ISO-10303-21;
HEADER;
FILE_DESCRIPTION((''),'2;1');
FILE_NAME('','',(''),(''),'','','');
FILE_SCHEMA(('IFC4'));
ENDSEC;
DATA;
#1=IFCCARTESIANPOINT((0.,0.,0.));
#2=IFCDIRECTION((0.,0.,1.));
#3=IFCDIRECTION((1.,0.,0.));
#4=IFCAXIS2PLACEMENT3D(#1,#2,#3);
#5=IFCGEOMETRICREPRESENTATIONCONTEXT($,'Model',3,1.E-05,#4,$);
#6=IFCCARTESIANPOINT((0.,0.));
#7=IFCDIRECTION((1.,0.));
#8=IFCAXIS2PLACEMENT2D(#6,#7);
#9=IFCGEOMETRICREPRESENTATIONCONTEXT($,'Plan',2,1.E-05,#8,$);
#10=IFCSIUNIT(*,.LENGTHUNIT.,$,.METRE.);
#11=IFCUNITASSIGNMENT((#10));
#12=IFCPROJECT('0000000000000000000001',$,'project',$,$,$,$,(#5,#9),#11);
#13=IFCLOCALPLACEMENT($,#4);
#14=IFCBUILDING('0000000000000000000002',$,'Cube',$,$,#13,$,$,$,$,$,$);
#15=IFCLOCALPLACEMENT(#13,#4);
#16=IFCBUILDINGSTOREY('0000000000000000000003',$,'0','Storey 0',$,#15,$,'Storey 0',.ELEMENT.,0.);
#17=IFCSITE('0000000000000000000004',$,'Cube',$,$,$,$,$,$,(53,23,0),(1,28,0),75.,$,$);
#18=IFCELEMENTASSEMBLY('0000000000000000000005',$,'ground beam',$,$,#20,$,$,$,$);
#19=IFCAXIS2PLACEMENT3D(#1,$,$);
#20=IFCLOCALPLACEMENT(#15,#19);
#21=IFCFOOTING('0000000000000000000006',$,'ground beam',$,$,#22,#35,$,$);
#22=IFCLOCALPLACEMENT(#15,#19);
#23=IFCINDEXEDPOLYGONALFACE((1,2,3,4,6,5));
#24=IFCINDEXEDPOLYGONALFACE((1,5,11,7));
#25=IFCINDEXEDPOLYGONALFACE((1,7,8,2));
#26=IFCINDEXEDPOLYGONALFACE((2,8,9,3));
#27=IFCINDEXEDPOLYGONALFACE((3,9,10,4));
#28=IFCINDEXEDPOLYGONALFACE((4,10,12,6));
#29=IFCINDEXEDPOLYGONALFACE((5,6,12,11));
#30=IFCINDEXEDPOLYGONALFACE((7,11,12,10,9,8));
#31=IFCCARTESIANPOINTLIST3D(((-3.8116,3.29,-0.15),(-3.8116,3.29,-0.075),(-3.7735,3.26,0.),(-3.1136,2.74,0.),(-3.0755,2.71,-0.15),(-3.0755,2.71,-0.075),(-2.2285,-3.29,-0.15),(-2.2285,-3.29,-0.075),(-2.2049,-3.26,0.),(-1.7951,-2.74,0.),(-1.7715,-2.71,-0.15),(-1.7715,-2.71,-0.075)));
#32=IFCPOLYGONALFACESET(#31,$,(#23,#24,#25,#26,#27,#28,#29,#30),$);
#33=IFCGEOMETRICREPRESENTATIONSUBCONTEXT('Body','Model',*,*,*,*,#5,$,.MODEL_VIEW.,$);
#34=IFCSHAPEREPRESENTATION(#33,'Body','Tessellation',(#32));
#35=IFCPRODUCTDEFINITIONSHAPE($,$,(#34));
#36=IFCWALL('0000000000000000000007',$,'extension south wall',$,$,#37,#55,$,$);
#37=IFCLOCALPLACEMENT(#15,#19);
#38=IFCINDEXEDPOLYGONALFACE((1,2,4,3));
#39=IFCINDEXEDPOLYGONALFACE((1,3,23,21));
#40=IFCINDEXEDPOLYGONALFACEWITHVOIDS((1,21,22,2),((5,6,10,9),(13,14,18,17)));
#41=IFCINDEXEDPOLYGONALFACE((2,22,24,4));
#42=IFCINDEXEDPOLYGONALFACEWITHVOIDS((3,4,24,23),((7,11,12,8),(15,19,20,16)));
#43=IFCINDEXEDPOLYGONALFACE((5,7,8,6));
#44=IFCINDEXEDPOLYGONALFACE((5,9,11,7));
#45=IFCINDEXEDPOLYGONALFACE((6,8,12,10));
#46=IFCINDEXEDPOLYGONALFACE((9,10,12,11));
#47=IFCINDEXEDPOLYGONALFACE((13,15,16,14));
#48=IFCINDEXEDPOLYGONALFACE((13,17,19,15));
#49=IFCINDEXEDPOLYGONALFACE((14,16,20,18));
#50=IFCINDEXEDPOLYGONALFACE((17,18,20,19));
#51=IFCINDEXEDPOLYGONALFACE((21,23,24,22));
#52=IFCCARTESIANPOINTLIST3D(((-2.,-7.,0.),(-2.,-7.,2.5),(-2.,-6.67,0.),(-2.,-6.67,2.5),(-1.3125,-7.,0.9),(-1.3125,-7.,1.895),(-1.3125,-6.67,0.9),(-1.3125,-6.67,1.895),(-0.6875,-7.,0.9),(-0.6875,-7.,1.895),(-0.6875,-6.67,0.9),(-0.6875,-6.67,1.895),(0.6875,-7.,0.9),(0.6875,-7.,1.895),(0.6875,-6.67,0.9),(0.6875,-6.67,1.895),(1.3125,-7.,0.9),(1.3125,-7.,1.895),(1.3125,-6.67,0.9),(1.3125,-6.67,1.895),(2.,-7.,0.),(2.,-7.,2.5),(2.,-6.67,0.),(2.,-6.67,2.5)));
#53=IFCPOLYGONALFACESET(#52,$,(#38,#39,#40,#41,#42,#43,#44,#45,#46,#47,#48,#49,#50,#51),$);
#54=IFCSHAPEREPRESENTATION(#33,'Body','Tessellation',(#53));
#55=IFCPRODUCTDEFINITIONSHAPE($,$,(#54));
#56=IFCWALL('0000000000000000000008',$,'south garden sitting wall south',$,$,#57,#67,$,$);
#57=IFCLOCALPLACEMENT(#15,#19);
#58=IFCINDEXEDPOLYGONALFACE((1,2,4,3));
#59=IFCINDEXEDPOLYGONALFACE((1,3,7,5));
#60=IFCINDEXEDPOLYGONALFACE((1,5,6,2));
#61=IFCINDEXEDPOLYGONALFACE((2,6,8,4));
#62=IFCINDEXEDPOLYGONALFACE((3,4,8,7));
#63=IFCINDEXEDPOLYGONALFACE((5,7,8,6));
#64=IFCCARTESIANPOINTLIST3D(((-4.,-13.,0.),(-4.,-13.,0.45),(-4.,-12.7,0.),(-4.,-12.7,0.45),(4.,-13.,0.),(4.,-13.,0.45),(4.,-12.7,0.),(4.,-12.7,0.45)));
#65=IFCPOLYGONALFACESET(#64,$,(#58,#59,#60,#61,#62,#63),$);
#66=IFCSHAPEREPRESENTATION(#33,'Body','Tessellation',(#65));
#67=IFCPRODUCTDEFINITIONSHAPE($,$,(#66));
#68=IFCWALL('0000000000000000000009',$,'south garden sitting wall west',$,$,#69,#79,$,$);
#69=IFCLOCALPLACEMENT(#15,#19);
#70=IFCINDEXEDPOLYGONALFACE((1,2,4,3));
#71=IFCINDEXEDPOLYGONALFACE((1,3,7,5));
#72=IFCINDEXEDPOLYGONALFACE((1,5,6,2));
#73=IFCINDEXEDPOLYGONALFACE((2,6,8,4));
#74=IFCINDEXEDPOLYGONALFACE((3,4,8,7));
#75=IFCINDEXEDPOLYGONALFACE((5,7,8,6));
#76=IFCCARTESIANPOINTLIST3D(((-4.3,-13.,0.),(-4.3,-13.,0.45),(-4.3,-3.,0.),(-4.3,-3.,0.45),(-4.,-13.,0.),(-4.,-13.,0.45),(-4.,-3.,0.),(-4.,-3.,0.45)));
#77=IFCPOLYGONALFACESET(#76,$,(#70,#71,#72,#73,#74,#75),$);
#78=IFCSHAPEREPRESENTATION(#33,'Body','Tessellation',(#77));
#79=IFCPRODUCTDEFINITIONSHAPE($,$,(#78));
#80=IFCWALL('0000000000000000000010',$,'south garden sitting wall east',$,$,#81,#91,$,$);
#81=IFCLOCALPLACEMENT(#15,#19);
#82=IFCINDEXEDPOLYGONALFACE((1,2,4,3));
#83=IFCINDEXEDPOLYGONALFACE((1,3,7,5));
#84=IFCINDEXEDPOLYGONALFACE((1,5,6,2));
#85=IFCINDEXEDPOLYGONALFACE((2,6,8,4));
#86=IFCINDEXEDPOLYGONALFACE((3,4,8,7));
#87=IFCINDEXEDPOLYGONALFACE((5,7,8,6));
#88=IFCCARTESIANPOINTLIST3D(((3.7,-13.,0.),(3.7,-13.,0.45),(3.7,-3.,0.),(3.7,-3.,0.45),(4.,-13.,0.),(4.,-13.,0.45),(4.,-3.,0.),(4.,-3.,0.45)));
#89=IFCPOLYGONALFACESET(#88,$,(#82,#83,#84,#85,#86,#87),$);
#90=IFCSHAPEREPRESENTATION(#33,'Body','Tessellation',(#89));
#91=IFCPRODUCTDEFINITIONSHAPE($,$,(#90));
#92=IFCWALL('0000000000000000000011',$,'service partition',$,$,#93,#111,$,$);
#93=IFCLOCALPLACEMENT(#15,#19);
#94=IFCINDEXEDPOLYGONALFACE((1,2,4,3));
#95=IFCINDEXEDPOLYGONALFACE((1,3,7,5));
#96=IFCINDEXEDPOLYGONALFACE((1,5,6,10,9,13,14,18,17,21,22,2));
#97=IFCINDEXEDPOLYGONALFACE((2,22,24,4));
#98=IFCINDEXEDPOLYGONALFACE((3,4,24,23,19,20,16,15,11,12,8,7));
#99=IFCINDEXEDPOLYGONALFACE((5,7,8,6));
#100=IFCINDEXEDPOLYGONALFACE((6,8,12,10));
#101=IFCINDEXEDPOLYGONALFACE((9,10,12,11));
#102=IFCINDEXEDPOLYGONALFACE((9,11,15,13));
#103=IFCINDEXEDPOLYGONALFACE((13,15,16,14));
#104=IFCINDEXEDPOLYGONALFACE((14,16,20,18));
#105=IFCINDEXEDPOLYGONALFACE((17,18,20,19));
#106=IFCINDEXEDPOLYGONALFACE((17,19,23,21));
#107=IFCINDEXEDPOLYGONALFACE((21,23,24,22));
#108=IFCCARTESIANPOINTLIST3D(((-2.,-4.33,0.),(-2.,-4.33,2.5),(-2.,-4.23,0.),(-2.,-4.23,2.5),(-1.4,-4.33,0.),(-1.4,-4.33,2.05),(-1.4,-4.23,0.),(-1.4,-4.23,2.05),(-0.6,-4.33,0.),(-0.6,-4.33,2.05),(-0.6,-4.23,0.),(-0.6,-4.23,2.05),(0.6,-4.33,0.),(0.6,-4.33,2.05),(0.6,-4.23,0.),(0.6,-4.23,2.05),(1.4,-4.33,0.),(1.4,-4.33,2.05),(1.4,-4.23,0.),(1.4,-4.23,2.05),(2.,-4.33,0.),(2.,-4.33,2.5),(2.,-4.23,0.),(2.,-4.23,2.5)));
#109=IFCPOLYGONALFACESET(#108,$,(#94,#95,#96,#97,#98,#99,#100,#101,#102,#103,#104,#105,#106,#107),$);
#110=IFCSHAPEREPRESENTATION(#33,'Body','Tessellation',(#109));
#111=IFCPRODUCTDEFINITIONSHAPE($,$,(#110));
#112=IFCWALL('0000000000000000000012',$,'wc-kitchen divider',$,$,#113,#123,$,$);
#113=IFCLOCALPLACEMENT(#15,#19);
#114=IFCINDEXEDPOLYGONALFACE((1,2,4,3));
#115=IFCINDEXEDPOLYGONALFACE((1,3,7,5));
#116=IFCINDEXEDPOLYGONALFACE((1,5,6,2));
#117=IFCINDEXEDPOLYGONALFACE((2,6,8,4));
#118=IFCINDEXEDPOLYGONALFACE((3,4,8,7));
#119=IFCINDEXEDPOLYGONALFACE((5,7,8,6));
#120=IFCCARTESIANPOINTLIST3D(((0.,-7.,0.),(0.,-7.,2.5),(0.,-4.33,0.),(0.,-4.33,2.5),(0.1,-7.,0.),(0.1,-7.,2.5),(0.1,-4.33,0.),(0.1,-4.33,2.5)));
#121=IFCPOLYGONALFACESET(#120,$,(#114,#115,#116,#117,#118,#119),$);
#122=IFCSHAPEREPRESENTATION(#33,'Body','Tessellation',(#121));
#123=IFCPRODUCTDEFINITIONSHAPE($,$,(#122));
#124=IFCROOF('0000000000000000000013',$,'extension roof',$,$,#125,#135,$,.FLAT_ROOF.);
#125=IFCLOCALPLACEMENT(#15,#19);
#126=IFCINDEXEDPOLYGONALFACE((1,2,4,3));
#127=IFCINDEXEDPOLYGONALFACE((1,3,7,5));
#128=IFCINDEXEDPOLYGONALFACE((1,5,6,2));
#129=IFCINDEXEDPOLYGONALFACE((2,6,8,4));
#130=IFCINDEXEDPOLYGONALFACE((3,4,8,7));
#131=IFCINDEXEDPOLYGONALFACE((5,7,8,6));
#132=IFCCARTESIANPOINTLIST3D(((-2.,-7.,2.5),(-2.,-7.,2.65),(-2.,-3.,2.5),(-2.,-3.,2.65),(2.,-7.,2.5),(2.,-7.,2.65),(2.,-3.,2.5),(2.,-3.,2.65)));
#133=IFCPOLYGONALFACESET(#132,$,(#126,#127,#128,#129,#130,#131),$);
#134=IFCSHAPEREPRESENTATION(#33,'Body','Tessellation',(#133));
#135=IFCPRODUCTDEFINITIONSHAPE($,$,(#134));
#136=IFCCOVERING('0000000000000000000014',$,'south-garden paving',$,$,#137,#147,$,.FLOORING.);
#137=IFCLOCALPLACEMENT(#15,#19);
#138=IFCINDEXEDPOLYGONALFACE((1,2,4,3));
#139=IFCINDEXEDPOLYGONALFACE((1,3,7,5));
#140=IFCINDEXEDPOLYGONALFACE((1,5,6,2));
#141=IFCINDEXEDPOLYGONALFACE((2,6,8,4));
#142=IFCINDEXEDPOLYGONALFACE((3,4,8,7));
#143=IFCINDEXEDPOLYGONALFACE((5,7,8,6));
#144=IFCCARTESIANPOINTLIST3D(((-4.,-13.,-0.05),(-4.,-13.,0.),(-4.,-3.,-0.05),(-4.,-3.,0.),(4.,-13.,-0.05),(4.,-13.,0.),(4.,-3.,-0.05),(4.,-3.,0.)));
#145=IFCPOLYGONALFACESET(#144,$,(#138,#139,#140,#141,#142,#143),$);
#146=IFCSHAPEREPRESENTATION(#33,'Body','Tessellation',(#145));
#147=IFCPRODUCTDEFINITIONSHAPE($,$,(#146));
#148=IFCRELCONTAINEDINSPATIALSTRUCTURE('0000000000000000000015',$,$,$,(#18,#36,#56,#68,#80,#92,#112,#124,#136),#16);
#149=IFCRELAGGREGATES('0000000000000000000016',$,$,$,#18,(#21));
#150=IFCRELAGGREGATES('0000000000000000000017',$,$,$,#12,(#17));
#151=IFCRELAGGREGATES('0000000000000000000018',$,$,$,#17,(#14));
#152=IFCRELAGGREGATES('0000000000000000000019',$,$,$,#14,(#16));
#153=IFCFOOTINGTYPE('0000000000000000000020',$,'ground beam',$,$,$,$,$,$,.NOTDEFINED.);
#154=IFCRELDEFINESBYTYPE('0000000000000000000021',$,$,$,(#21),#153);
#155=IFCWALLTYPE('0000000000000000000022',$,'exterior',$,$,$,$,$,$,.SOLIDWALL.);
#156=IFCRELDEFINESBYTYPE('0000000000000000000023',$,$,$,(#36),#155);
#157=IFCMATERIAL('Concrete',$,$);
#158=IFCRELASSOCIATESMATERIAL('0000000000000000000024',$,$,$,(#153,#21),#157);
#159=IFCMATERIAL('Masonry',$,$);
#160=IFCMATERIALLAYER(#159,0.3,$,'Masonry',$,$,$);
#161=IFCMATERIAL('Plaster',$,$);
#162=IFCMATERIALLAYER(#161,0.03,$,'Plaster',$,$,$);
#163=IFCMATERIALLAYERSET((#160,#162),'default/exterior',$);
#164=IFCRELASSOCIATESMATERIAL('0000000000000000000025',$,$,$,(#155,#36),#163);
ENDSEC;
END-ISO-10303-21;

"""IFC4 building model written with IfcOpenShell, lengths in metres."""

from ifc_helpers import new_model, si_unit, frame, origin_with_axes, origin_2d_with_axis, place, context, subcontext, project, spatial, polyline, indexed_curve, outline, extrude, clip, halfspace, material, layer, layer_set, layer_usage, material_profile, profile_set, profile_usage, type_object, element, aggregate, save


model = new_model("IFC4")

# Units and contexts
model_context = context("Model", 3, precision=1e-05, world=origin_with_axes())
plan_context = context("Plan", 2, precision=1e-05, world=origin_2d_with_axis())
body_context_1 = subcontext(model_context, "Body", "Model", "MODEL_VIEW")
ifc_project = project(units=[si_unit("LENGTHUNIT", "METRE")], contexts=[model_context, plan_context])

# Site, building, storey
site = spatial("IfcSite", under=ifc_project, Name="Cube", RefLatitude=(53, 23, 0), RefLongitude=(1, 28, 0), RefElevation=75.0)
building_placement = place(None, origin_with_axes())
building = spatial("IfcBuilding", under=site, at=building_placement, Name="Cube")
storey_placement = place(building_placement, origin_with_axes())
storey = spatial("IfcBuildingStorey", under=building, at=storey_placement, Name="0", Description="Storey 0", LongName="Storey 0", CompositionType="ELEMENT", Elevation=0.0)

# Element assembly, footing
assembly_placement = place(storey_placement, origin_with_axes())
assembly = element("IfcElementAssembly", 1, at=assembly_placement, inside=storey, Name="ground beam")
ifc_material_1 = material(Name="Concrete")
ifc_material_profile = material_profile(ifc_material_1, outline(polyline([(-0.26, 0.0), (-0.29, -0.075), (-0.29, -0.15), (0.29, -0.15), (0.29, -0.075), (0.26, 0.0), (-0.26, 0.0)])))
ifc_profile_set = profile_set([ifc_material_profile])
ifc_profile_usage = profile_usage(ifc_profile_set)
footing_type = type_object("IfcFootingType", Name="ground beam", PredefinedType="NOTDEFINED", material=ifc_profile_set)
footing_placement = place(assembly_placement, frame((-1.7661, -3.9723, 0.0), z_axis=(-0.233915, 0.972257, 0.0), x_axis=(-0.972257, -0.233915, 0.0)))
footing = element("IfcFooting", 2, at=footing_placement, type_object=footing_type, material=ifc_profile_usage, Name="ground beam", context=body_context_1, shape_type="Clipping", body=[
    clip(clip(extrude(outline(polyline([(-0.26, 0.0), (-0.29, -0.075), (-0.29, -0.15), (0.29, -0.15), (0.29, -0.075), (0.26, 0.0), (-0.26, 0.0)])), origin_with_axes(), (0.0, 0.0, 1.0), 8.1712), halfspace(frame((0.0, 0.0, 1.0), z_axis=(-0.618904, 0.0, -0.785467), x_axis=(0.0, 1.0, 0.0)), False)), halfspace(frame((0.0, 0.0, 7.1712), z_axis=(-0.785467, 0.0, 0.618904), x_axis=(0.0, 1.0, 0.0)), False)),
])
aggregate(assembly, [footing])

# Wall, openings
ifc_material_2 = material(Name="Masonry")
ifc_layer_1 = layer(ifc_material_2, 0.3, Name="Masonry")
ifc_material_3 = material(Name="Plaster")
ifc_layer_2 = layer(ifc_material_3, 0.03, Name="Plaster")
ifc_layer_set = layer_set([ifc_layer_1, ifc_layer_2], Name="default/exterior")
ifc_layer_usage = layer_usage(ifc_layer_set, "AXIS2", "POSITIVE", 0.0)
wall_type = type_object("IfcWallType", Name="exterior", PredefinedType="SOLIDWALL", material=ifc_layer_set)
wall_1_placement = place(storey_placement, frame((-2.0, -7.0, 0.0), z_axis=(0.0, 0.0, 1.0), x_axis=(1.0, 0.0, 0.0)))
wall_1 = element("IfcWall", 3, at=wall_1_placement, inside=storey, type_object=wall_type, material=ifc_layer_usage, Name="extension south wall", context=body_context_1, shape_type="SweptSolid", body=[
    extrude(outline(indexed_curve([(0.0, 0.0), (0.0, 0.33), (4.0, 0.33), (4.0, 0.0), (0.0, 0.0)], self_intersect=False)), origin_with_axes(), (0.0, 0.0, 1.0), 2.5),
])
opening_1_placement = place(wall_1_placement, frame((0.6875, 0.0, 0.9), z_axis=(0.0, 0.0, 1.0), x_axis=(1.0, 0.0, 0.0)))
element("IfcOpeningElement", 4, at=opening_1_placement, cuts=wall_1, PredefinedType="OPENING", context=body_context_1, shape_type="SweptSolid", body=[
    extrude(outline(indexed_curve([(0.0, 0.0), (0.0, 0.5), (0.625, 0.5), (0.625, 0.0), (0.0, 0.0)], self_intersect=False)), origin_with_axes(), (0.0, 0.0, 1.0), 0.995),
])
opening_2_placement = place(wall_1_placement, frame((2.6875, 0.0, 0.9), z_axis=(0.0, 0.0, 1.0), x_axis=(1.0, 0.0, 0.0)))
element("IfcOpeningElement", 5, at=opening_2_placement, cuts=wall_1, PredefinedType="OPENING", context=body_context_1, shape_type="SweptSolid", body=[
    extrude(outline(indexed_curve([(0.0, 0.0), (0.0, 0.5), (0.625, 0.5), (0.625, 0.0), (0.0, 0.0)], self_intersect=False)), origin_with_axes(), (0.0, 0.0, 1.0), 0.995),
])

# Walls
wall_2_placement = place(storey_placement, frame((-4.0, -13.0, 0.0), z_axis=(0.0, 0.0, 1.0), x_axis=(1.0, 0.0, 0.0)))
element("IfcWall", 6, at=wall_2_placement, inside=storey, Name="south garden sitting wall south", context=body_context_1, shape_type="SweptSolid", body=[
    extrude(outline(indexed_curve([(0.0, 0.0), (0.0, 0.3), (8.0, 0.3), (8.0, 0.0), (0.0, 0.0)], self_intersect=False)), origin_with_axes(), (0.0, 0.0, 1.0), 0.45),
])
for number, where, z_axis, x_axis, name in (
    (7, (-4.0, -13.0, 0.0), (0.0, 0.0, 1.0), (0.0, 1.0, 0.0), "south garden sitting wall west"),
    (8, (4.0, -13.0, 0.0), (0.0, 0.0, 1.0), (0.0, 1.0, 0.0), "south garden sitting wall east"),
):
    element("IfcWall", number, at=place(storey_placement, frame(where, z_axis=z_axis, x_axis=x_axis)), inside=storey, Name=name, context=body_context_1, shape_type="SweptSolid", body=[
        extrude(outline(indexed_curve([(0.0, 0.0), (0.0, 0.3), (10.0, 0.3), (10.0, 0.0), (0.0, 0.0)], self_intersect=False)), origin_with_axes(), (0.0, 0.0, 1.0), 0.45),
    ])

# Wall, openings
wall_3_placement = place(storey_placement, frame((-2.0, -4.33, 0.0), z_axis=(0.0, 0.0, 1.0), x_axis=(1.0, 0.0, 0.0)))
wall_3 = element("IfcWall", 9, at=wall_3_placement, inside=storey, Name="service partition", context=body_context_1, shape_type="SweptSolid", body=[
    extrude(outline(indexed_curve([(0.0, 0.0), (0.0, 0.1), (4.0, 0.1), (4.0, 0.0), (0.0, 0.0)], self_intersect=False)), origin_with_axes(), (0.0, 0.0, 1.0), 2.5),
])
opening_3_placement = place(wall_3_placement, frame((0.6, -0.05, 0.0), z_axis=(0.0, 0.0, 1.0), x_axis=(1.0, 0.0, 0.0)))
element("IfcOpeningElement", 10, at=opening_3_placement, cuts=wall_3, context=body_context_1, shape_type="SweptSolid", body=[
    extrude(outline(indexed_curve([(0.0, 0.0), (0.0, 0.3), (0.8, 0.3), (0.8, 0.0), (0.0, 0.0)], self_intersect=False)), origin_with_axes(), (0.0, 0.0, 1.0), 2.05),
])
opening_4_placement = place(wall_3_placement, frame((2.6, -0.05, 0.0), z_axis=(0.0, 0.0, 1.0), x_axis=(1.0, 0.0, 0.0)))
element("IfcOpeningElement", 11, at=opening_4_placement, cuts=wall_3, context=body_context_1, shape_type="SweptSolid", body=[
    extrude(outline(indexed_curve([(0.0, 0.0), (0.0, 0.3), (0.8, 0.3), (0.8, 0.0), (0.0, 0.0)], self_intersect=False)), origin_with_axes(), (0.0, 0.0, 1.0), 2.05),
])

# Wall
wall_4_placement = place(storey_placement, frame((0.0, -4.33, 0.0), z_axis=(0.0, 0.0, 1.0), x_axis=(0.0, -1.0, 0.0)))
element("IfcWall", 12, at=wall_4_placement, inside=storey, Name="wc-kitchen divider", context=body_context_1, shape_type="SweptSolid", body=[
    extrude(outline(indexed_curve([(0.0, 0.0), (0.0, 0.1), (2.67, 0.1), (2.67, 0.0), (0.0, 0.0)], self_intersect=False)), origin_with_axes(), (0.0, 0.0, 1.0), 2.5),
])

# Roof
roof_placement = place(storey_placement, frame((-2.0, -7.0, 2.5), z_axis=(0.0, 0.0, 1.0), x_axis=(1.0, 0.0, 0.0)))
element("IfcRoof", 13, at=roof_placement, inside=storey, Name="extension roof", PredefinedType="FLAT_ROOF", context=body_context_1, shape_type="SweptSolid", body=[
    extrude(outline(indexed_curve([(0.0, 0.0), (4.0, 0.0), (4.0, 4.0), (0.0, 4.0)])), None, (0.0, 0.0, 1.0), 0.15),
])

# Covering
covering_placement = place(storey_placement, frame((-4.0, -13.0, 0.0), z_axis=(0.0, 0.0, 1.0), x_axis=(1.0, 0.0, 0.0)))
element("IfcCovering", 14, at=covering_placement, inside=storey, Name="south-garden paving", PredefinedType="FLOORING", context=body_context_1, shape_type="SweptSolid", body=[
    extrude(outline(indexed_curve([(0.0, 0.0), (8.0, 0.0), (8.0, 10.0), (0.0, 10.0)])), None, (0.0, 0.0, -1.0), 0.05),
])

save(model, "model.ifc")
